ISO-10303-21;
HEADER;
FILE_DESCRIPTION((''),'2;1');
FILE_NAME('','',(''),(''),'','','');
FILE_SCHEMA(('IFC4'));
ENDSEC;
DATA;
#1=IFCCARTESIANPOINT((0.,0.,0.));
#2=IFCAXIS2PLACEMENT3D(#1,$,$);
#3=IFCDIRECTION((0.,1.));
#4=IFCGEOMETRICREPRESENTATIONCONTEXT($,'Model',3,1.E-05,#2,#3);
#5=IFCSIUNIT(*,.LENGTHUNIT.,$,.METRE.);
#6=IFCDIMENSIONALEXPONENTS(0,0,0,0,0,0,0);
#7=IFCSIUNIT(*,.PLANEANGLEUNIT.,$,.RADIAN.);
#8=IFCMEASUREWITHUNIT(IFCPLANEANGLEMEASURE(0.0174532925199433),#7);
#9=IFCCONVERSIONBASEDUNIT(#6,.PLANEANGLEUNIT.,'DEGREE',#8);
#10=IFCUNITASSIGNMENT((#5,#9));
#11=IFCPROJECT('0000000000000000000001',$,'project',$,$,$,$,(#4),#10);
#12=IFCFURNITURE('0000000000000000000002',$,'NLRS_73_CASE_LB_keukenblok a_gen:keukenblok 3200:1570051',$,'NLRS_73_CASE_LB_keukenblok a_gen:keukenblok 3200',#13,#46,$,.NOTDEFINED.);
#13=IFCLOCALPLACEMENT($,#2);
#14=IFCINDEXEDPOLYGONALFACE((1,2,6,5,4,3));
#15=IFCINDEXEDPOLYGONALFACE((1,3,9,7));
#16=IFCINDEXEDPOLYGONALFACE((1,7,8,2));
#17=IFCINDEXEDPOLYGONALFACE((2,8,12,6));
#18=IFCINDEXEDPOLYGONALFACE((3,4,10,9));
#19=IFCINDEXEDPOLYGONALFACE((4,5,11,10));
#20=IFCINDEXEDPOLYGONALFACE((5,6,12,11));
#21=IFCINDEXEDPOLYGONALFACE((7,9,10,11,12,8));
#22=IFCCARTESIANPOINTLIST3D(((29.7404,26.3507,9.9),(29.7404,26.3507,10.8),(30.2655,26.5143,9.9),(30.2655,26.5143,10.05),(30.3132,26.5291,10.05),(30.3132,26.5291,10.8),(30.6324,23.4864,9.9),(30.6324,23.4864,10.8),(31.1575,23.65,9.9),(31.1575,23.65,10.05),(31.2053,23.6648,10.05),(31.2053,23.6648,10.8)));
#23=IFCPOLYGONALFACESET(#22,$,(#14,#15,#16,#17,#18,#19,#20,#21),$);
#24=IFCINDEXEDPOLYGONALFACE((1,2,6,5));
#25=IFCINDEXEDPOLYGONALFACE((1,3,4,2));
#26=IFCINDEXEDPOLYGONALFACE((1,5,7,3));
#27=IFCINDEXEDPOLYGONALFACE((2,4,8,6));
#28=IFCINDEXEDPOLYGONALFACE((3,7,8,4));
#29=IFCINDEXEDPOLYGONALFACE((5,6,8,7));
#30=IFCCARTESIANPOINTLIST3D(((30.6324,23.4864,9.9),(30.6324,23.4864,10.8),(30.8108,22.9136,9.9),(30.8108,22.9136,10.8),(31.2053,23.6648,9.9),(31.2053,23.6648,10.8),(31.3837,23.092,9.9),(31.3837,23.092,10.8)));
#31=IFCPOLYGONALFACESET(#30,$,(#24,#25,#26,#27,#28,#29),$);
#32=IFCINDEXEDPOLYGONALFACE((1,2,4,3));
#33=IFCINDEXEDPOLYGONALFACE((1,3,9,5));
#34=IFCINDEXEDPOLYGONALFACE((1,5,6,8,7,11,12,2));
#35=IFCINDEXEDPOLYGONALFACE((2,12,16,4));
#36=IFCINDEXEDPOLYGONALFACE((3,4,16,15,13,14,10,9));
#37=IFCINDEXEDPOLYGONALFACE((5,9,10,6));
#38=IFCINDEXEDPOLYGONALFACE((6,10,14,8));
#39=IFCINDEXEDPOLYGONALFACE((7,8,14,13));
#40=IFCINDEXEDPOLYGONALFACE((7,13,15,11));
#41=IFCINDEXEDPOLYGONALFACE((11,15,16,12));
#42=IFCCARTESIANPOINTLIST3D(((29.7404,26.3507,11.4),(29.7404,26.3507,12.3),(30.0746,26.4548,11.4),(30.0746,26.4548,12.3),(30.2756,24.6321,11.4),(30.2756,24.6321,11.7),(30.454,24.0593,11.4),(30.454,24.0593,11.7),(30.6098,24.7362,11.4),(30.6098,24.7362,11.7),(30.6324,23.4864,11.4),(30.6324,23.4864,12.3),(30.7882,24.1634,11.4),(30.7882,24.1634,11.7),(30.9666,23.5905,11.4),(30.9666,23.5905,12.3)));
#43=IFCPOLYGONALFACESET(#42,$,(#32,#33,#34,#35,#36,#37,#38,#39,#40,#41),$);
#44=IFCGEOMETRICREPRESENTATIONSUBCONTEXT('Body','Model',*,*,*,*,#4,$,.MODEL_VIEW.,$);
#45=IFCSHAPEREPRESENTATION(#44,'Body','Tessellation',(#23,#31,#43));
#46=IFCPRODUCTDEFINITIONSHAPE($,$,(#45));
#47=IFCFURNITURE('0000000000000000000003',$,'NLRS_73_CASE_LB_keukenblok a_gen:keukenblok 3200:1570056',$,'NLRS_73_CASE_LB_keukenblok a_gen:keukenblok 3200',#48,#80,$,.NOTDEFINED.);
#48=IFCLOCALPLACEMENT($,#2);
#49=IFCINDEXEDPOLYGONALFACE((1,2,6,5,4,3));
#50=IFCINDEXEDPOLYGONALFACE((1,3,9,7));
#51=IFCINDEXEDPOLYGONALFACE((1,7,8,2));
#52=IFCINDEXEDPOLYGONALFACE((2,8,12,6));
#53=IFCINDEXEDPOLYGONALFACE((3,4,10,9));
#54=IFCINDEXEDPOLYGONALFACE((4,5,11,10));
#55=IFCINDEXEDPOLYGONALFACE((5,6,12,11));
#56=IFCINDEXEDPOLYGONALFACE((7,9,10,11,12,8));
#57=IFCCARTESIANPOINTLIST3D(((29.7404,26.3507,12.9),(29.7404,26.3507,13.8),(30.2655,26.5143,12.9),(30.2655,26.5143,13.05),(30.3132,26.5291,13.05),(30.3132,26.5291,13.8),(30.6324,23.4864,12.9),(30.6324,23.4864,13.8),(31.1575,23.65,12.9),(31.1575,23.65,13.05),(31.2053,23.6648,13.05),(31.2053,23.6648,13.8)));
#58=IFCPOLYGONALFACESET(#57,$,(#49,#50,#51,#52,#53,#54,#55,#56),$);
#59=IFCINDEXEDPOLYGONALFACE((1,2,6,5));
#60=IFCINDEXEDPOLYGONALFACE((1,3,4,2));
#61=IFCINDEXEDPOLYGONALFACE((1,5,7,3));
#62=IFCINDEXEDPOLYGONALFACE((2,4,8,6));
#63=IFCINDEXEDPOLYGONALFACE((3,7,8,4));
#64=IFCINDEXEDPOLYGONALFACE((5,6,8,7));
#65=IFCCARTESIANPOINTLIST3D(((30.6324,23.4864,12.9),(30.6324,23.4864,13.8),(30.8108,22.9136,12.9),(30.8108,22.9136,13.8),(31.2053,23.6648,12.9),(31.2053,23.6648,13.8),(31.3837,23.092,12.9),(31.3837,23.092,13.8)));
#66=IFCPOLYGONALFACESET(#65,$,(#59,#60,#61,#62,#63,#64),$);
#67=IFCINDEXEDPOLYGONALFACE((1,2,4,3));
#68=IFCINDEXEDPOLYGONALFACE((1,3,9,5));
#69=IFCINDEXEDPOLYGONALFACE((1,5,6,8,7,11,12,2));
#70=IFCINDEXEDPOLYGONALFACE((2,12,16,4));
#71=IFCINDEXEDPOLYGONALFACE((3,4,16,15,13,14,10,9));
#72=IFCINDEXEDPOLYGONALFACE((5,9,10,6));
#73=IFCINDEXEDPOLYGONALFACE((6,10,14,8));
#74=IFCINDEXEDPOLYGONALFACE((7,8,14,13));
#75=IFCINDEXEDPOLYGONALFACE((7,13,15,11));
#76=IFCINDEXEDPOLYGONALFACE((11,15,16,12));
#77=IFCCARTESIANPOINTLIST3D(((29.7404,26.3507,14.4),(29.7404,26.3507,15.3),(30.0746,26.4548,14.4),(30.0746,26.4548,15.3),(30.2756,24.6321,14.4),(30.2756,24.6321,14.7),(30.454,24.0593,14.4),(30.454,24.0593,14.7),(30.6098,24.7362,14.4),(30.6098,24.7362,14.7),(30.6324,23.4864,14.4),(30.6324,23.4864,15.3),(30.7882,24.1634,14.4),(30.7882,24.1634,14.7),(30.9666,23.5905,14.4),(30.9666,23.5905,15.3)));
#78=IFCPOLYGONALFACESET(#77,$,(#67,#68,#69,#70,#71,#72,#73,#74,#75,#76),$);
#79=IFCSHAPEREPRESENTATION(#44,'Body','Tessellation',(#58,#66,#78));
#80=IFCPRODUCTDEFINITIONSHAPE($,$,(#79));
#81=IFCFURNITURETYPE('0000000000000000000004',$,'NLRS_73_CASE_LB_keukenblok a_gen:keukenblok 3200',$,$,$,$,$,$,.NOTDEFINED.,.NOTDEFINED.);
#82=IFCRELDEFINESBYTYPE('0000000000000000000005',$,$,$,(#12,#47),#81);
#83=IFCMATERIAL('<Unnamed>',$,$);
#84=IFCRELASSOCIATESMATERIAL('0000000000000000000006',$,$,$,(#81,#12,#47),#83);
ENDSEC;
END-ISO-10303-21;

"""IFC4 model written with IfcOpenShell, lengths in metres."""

from ifc_helpers import new_model, entity, si_unit, converted_unit, direction, frame, origin, place, context, subcontext, project, indexed_curve, outline, extrude, source, transform, mapped, material, type_object, type_shapes, element, save


model = new_model("IFC4")

# Units and contexts
model_context = context("Model", 3, precision=1e-05, world=origin(), true_north=direction((0.0, 1.0)))
body_context = subcontext(model_context, "Body", "Model", "MODEL_VIEW")
ifc_project = project(units=[si_unit("LENGTHUNIT", "METRE"), converted_unit("PLANEANGLEUNIT", "DEGREE", entity("IfcPlaneAngleMeasure", 0.0174532925199433), si_unit("PLANEANGLEUNIT", "RADIAN"), dimensions=[0, 0, 0, 0, 0, 0, 0])], contexts=[model_context])

# Shared definitions
ifc_material = material(Name="<Unnamed>")
placement_1 = place(None, frame((13.1348, 11.9886, 0.0), z_axis=(0.0, 0.0, 1.0), x_axis=(0.954771, 0.297342, 0.0)))
placement_2 = place(placement_1, origin())
placement_3 = place(placement_2, frame((0.0, 0.0, 9.9)))
placement_4 = place(placement_2, frame((0.0, 0.0, 12.9)))

# Furniture
furniture_type = type_object("IfcFurnitureType", Name="NLRS_73_CASE_LB_keukenblok a_gen:keukenblok 3200", AssemblyPlace="NOTDEFINED", PredefinedType="NOTDEFINED", material=ifc_material)
shared_shape_1 = source(origin(), body_context, "Body", "SweptSolid", [
    extrude(outline(indexed_curve([(-0.35, 0.1667), (-0.35, -0.3833), (0.55, -0.3833), (0.55, 0.2167), (-0.2, 0.2167), (-0.2, 0.1667), (-0.35, 0.1667)], self_intersect=False)), frame((0.0, 0.3833, 0.35), z_axis=(-1.0, 0.0, 0.0), x_axis=(0.0, 0.0, 1.0)), (0.0, 0.0, -1.0), 3.0),
    extrude(outline(indexed_curve([(-0.3, -0.3), (0.3, -0.3), (0.3, 0.3), (-0.3, 0.3), (-0.3, -0.3)], self_intersect=False)), frame((3.3, 0.3, 0.0), z_axis=(0.0, 0.0, 1.0), x_axis=(0.0, 1.0, 0.0)), (0.0, 0.0, 1.0), 0.9),
    extrude(outline(indexed_curve([(-1.2, -0.3), (-0.6, -0.3), (-0.6, 0.0), (0.0, 0.0), (0.0, -0.3), (1.8, -0.3), (1.8, 0.6), (-1.2, 0.6), (-1.2, -0.3)], self_intersect=False)), frame((1.8, 0.0, 1.8), z_axis=(0.0, 1.0, 0.0), x_axis=(-1.0, 0.0, 0.0)), (0.0, 0.0, 1.0), 0.35),
])
type_shapes(furniture_type, [shared_shape_1])
placement_5 = place(placement_3, origin())
furniture_1_placement = place(placement_5, frame((20.125, 8.775, 0.0), z_axis=(0.0, 0.0, 1.0), x_axis=(0.0, -1.0, 0.0)))
element("IfcFurniture", 1, at=furniture_1_placement, type_object=furniture_type, material=ifc_material, Name="NLRS_73_CASE_LB_keukenblok a_gen:keukenblok 3200:1570051", ObjectType="NLRS_73_CASE_LB_keukenblok a_gen:keukenblok 3200", PredefinedType="NOTDEFINED", context=body_context, shape_type="MappedRepresentation", body=[
    mapped(shared_shape_1, transform((0.0, 0.0, 0.0), scale=1.0)),
])
placement_6 = place(placement_4, origin())
furniture_2_placement = place(placement_6, frame((20.125, 8.775, 0.0), z_axis=(0.0, 0.0, 1.0), x_axis=(0.0, -1.0, 0.0)))
element("IfcFurniture", 2, at=furniture_2_placement, type_object=furniture_type, material=ifc_material, Name="NLRS_73_CASE_LB_keukenblok a_gen:keukenblok 3200:1570056", ObjectType="NLRS_73_CASE_LB_keukenblok a_gen:keukenblok 3200", PredefinedType="NOTDEFINED", context=body_context, shape_type="MappedRepresentation", body=[
    mapped(shared_shape_1, transform((0.0, 0.0, 0.0), scale=1.0)),
])

save(model, "model.ifc")
